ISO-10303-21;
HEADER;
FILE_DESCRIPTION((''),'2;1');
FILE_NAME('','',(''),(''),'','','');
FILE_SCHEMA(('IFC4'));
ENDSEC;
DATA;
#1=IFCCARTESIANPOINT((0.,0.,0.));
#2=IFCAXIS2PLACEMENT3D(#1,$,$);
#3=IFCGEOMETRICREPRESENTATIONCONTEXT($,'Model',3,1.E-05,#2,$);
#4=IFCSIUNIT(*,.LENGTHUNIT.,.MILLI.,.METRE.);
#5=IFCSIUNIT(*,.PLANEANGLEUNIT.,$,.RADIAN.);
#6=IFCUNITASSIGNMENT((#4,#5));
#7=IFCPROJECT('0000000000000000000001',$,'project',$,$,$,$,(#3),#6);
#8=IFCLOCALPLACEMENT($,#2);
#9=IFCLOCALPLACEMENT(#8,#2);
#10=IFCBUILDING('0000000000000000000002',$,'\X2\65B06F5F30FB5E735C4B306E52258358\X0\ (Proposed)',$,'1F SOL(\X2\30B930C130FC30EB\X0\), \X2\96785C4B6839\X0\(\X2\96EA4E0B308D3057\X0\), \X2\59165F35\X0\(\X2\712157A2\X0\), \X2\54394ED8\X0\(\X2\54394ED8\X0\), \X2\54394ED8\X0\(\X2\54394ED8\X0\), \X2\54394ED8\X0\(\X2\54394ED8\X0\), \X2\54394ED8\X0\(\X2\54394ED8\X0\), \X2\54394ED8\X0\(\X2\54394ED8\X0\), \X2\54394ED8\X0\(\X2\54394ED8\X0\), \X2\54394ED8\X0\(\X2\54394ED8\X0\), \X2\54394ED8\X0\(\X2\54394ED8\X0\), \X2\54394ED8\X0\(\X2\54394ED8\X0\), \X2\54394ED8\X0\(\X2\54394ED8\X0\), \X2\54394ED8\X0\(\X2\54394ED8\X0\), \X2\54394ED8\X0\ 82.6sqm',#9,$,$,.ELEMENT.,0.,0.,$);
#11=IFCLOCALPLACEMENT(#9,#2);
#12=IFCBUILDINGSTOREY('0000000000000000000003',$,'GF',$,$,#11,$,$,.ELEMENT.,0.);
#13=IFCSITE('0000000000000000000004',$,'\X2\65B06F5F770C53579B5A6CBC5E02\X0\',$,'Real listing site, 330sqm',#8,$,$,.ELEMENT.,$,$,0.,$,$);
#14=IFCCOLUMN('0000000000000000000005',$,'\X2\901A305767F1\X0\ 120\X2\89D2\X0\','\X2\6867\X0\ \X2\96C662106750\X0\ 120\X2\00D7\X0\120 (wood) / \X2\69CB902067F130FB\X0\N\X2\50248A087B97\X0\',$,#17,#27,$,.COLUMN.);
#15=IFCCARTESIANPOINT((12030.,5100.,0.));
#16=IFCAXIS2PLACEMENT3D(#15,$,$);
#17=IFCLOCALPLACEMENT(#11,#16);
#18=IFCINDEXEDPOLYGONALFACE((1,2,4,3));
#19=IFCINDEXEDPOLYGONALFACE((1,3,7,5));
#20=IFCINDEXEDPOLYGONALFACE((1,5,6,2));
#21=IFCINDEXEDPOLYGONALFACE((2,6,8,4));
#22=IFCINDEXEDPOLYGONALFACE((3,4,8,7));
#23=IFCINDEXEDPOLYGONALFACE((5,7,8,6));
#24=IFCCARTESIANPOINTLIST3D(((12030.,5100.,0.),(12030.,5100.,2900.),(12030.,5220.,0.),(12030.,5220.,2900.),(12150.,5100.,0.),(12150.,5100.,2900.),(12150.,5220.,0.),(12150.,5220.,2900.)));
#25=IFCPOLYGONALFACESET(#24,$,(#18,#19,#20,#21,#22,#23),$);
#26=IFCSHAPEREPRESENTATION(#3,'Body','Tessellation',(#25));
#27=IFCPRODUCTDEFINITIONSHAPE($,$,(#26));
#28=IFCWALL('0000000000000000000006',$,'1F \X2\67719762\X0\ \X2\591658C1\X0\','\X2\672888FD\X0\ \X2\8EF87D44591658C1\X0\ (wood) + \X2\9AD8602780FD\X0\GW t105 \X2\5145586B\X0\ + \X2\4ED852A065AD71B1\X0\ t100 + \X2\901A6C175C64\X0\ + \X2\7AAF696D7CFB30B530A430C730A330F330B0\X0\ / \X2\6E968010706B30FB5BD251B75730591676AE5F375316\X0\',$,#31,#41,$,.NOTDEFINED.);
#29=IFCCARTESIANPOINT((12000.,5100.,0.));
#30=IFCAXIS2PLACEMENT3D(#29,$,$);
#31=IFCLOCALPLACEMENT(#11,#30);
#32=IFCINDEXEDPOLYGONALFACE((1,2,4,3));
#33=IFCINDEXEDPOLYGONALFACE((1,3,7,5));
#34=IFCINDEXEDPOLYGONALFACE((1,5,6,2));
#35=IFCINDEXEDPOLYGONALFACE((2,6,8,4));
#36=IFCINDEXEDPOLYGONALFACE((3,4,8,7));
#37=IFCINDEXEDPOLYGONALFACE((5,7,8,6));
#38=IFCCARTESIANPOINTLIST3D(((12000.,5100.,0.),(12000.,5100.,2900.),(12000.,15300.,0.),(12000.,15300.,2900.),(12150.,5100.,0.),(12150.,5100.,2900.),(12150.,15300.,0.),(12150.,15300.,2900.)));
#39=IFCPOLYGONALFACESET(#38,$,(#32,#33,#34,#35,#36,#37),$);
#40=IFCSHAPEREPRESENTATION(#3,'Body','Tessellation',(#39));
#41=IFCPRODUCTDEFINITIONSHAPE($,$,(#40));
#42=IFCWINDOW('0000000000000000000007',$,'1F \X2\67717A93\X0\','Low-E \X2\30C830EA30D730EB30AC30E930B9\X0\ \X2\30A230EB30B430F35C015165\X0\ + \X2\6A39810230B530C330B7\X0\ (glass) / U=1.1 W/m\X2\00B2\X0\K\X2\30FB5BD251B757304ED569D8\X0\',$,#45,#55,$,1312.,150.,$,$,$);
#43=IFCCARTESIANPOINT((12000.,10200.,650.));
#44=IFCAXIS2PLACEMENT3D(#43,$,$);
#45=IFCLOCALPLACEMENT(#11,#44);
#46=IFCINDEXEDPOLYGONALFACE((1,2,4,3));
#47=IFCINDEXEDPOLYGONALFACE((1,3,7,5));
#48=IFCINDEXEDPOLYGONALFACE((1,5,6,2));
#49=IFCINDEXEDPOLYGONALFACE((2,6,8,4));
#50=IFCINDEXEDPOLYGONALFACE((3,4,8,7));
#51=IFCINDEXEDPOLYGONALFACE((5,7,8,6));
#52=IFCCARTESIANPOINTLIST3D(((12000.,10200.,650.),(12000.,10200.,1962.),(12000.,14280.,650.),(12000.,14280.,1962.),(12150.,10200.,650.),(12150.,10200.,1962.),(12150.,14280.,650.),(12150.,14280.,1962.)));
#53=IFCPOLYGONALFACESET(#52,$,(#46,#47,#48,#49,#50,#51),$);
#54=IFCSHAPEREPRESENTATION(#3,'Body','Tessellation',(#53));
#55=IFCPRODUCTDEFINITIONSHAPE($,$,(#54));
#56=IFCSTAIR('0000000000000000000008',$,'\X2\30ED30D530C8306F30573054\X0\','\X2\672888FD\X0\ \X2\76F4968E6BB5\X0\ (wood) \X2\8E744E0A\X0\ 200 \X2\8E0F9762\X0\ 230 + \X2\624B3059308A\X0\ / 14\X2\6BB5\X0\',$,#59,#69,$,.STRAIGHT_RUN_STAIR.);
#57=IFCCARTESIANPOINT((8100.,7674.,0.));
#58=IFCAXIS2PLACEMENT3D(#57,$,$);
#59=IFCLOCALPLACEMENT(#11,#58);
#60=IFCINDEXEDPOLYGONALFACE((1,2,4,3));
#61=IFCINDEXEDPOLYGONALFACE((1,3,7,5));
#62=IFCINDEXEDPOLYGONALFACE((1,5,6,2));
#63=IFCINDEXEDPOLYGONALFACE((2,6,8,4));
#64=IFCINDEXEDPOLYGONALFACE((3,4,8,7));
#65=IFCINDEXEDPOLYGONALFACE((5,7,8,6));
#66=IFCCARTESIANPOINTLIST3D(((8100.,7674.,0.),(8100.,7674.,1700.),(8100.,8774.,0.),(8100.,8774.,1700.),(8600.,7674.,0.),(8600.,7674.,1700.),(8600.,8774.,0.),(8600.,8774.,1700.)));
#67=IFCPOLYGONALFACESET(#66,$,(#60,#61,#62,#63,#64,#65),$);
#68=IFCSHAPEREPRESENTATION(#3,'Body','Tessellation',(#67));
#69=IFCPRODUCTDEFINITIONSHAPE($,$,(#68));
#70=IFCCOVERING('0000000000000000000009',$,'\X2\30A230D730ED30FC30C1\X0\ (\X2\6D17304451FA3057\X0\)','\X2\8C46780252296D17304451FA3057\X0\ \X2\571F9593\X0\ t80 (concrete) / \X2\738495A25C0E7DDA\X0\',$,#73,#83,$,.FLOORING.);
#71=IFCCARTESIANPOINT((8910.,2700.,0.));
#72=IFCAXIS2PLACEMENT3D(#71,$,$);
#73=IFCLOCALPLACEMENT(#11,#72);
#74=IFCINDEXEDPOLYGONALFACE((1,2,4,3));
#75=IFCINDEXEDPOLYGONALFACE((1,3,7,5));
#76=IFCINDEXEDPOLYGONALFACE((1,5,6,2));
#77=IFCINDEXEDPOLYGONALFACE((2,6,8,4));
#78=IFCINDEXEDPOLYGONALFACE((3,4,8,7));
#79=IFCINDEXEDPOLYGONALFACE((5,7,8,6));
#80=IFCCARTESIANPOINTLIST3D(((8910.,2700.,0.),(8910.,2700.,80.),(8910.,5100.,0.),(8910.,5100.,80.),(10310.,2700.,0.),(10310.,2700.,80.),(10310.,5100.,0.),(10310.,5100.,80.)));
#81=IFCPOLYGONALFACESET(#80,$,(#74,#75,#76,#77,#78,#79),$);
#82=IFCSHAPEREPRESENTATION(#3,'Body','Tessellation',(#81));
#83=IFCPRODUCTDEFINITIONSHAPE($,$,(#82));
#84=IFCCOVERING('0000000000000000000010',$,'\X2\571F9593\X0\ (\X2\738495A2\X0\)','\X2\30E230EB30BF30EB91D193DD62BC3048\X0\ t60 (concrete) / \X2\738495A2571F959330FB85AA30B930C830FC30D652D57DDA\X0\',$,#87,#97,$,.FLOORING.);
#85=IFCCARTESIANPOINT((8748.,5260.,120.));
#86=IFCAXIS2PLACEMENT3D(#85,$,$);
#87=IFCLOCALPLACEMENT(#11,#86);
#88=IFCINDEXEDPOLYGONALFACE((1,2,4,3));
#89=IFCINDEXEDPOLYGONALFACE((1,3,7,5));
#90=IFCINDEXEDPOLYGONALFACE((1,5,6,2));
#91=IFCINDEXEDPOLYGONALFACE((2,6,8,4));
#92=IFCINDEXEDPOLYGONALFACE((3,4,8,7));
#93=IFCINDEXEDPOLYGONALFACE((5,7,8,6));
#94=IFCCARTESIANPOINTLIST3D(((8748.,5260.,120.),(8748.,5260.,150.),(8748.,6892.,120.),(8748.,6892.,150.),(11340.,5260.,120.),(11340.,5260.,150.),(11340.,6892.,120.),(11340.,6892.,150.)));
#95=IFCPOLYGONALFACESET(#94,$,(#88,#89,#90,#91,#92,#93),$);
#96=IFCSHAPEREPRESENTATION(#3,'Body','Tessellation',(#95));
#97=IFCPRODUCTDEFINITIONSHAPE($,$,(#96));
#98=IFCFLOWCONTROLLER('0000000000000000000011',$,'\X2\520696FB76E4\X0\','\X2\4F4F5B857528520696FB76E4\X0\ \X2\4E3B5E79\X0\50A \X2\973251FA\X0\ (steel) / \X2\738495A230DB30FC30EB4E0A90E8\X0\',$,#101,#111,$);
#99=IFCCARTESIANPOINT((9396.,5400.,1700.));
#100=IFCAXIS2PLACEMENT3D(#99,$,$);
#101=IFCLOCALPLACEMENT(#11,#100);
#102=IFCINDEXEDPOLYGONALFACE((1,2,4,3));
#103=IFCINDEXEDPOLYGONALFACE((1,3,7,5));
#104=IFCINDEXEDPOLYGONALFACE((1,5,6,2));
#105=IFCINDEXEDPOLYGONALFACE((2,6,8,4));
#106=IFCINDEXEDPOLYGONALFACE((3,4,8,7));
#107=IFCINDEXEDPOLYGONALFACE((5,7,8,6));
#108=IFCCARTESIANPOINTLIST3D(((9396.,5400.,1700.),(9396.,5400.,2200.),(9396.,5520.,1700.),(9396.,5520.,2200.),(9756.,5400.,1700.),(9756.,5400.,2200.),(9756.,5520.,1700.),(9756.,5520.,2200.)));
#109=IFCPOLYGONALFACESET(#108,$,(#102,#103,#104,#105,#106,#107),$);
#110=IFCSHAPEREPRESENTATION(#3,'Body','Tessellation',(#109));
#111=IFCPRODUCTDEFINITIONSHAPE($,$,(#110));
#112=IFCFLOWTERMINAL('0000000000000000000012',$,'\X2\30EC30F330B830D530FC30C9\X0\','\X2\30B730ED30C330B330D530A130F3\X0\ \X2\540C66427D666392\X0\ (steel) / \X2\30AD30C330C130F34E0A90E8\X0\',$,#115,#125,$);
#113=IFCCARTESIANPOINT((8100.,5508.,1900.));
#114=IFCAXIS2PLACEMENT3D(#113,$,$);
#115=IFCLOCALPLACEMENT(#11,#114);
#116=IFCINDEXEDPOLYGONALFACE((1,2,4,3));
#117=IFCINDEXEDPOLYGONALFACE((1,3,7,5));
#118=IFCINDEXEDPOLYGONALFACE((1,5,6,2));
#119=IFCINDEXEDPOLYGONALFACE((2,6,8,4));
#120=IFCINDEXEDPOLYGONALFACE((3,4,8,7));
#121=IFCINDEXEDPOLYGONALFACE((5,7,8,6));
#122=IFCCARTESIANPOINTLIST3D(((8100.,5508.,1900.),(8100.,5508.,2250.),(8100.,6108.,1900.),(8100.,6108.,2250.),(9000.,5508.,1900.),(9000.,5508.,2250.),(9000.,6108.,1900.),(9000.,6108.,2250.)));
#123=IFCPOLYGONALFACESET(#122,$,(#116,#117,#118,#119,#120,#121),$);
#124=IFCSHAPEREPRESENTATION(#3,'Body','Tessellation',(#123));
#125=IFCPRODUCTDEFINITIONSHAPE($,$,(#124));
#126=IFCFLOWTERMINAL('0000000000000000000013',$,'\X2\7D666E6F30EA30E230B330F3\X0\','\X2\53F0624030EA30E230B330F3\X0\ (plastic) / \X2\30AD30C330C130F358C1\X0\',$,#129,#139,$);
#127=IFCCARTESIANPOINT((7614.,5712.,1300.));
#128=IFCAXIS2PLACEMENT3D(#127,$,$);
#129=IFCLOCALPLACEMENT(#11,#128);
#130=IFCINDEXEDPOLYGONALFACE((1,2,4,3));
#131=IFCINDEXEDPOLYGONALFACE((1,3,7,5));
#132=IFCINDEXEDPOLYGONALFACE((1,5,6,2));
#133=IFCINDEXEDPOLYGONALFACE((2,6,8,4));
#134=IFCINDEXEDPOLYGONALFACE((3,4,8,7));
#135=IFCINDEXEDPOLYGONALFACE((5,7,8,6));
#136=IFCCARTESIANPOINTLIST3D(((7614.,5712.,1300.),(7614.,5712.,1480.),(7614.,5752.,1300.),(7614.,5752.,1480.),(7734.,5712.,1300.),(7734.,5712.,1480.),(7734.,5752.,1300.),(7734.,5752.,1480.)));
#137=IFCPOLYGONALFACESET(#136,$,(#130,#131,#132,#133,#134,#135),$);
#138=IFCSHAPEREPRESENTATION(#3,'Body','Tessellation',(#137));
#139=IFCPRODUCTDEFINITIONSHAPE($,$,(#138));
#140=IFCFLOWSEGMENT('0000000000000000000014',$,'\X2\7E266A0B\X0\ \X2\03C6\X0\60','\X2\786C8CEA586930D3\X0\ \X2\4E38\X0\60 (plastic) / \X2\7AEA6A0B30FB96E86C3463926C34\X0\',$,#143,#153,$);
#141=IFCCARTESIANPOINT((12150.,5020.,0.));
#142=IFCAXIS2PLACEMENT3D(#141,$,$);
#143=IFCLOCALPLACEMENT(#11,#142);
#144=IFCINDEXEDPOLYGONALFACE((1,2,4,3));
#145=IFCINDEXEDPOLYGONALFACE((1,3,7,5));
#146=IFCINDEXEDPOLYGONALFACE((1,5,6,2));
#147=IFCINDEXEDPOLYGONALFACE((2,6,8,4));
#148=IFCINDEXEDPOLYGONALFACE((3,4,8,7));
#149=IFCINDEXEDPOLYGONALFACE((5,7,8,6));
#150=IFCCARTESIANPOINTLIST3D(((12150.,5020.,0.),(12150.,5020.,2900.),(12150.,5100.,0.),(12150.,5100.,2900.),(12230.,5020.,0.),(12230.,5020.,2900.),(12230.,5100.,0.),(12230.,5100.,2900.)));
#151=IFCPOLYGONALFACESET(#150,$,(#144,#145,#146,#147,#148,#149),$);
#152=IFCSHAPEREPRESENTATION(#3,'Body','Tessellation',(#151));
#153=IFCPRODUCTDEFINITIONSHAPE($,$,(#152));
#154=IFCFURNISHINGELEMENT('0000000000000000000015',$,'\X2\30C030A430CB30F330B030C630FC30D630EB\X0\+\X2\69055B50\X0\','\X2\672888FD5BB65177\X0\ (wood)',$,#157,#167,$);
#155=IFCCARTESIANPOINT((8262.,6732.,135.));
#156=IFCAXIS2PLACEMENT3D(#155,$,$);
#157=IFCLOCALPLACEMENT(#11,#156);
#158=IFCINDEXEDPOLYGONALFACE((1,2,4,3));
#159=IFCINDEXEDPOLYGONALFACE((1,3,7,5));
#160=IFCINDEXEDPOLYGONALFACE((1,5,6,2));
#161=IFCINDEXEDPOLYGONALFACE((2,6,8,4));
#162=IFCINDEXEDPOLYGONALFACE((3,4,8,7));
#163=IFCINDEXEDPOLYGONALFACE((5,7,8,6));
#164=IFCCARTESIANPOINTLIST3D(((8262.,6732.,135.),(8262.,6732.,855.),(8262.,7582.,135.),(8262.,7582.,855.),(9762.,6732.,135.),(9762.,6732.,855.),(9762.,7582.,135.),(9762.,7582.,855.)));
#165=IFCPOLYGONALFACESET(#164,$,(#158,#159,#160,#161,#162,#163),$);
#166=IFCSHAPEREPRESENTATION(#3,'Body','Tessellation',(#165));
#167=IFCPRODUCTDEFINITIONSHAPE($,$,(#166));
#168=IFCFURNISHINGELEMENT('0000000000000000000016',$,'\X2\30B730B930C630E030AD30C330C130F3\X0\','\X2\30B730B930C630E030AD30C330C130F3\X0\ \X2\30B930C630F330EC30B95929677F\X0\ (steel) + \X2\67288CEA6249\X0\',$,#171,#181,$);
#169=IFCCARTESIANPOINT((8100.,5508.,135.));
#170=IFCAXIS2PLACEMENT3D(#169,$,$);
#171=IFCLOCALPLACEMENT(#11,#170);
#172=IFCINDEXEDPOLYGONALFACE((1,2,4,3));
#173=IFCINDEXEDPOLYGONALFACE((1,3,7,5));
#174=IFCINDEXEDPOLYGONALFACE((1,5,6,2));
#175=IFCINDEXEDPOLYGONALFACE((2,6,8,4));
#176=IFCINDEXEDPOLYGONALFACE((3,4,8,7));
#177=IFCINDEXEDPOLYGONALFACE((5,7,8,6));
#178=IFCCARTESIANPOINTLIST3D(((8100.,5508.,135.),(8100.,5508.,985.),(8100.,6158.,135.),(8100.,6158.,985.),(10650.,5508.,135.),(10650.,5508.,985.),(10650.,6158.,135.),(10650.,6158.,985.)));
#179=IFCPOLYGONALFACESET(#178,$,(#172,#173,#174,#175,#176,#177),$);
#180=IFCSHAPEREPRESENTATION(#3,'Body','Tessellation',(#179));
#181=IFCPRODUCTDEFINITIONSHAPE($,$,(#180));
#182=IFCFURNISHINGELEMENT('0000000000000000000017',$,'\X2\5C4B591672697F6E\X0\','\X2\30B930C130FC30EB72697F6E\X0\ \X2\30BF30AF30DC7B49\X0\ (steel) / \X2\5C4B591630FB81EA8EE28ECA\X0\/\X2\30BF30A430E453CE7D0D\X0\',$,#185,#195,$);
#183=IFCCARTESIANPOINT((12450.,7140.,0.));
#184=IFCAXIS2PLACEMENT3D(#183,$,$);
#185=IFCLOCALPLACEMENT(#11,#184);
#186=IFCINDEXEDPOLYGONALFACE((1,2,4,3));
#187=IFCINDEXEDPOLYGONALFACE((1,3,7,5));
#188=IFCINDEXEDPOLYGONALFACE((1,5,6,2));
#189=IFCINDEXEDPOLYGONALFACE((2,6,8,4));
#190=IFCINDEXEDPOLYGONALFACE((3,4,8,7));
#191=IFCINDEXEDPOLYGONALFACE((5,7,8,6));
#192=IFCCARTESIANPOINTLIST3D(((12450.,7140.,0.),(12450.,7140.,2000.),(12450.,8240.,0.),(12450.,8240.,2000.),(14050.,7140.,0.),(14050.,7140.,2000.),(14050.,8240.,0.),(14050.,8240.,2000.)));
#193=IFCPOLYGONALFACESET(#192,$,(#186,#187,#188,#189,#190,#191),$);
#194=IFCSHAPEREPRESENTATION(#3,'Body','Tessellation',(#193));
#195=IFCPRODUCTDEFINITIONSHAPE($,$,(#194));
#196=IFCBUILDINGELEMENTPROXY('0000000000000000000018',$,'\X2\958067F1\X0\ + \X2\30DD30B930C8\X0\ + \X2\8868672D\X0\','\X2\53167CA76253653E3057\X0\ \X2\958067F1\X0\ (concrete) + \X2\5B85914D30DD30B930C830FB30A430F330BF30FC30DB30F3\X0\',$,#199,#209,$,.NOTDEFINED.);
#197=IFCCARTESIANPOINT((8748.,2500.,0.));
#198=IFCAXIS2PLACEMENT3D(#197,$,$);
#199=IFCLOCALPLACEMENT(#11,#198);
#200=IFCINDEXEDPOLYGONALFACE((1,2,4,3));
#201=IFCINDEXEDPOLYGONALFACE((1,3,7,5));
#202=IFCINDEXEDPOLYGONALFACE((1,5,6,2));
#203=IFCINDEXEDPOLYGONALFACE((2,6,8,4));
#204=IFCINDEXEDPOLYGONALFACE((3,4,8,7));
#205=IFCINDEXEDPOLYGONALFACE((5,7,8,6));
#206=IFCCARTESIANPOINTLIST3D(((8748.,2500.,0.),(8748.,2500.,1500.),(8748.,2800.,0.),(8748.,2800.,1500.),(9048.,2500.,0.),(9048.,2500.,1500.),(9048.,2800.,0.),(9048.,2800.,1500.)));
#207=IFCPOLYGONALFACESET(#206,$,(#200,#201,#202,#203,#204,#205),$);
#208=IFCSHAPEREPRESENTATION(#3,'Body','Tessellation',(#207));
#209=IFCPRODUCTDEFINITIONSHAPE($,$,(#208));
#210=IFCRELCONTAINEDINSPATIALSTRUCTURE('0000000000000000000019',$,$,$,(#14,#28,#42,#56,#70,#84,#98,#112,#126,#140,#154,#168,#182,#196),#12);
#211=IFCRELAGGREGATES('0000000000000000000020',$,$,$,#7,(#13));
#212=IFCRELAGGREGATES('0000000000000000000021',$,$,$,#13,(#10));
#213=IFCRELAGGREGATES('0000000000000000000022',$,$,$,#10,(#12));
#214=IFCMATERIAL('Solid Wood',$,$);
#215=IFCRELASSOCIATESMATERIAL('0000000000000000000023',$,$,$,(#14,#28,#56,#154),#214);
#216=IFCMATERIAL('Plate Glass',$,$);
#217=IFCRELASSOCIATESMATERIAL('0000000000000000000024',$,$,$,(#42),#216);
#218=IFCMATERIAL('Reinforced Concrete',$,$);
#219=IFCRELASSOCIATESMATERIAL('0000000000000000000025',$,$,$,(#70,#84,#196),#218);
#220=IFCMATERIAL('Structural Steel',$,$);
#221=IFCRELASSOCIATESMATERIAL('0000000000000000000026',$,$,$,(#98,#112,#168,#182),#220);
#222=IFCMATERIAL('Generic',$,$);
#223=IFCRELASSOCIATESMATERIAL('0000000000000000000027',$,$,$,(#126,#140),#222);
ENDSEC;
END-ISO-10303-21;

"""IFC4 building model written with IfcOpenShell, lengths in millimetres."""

from ifc_helpers import new_model, si_unit, frame, frame_2d, origin, place, context, project, spatial, rectangle, extrude, material, element, fill, save


model = new_model("IFC4")

# Units and contexts
model_context = context("Model", 3, precision=1e-05, world=origin())
ifc_project = project(units=[si_unit("LENGTHUNIT", "METRE", prefix="MILLI"), si_unit("PLANEANGLEUNIT", "RADIAN")], contexts=[model_context])

# Site, building, storey
site_placement = place(None, origin())
site = spatial("IfcSite", under=ifc_project, at=site_placement, Name="新潟県南魚沼市", ObjectType="Real listing site, 330sqm", CompositionType="ELEMENT", RefElevation=0.0)
building_placement = place(site_placement, origin())
building = spatial("IfcBuilding", under=site, at=building_placement, Name="新潟・平屋の別荘 (Proposed)", ObjectType="1F SOL(スチール), 陸屋根(雪下ろし), 外張(無垢), 吹付(吹付), 吹付(吹付), 吹付(吹付), 吹付(吹付), 吹付(吹付), 吹付(吹付), 吹付(吹付), 吹付(吹付), 吹付(吹付), 吹付(吹付), 吹付(吹付), 吹付 82.6sqm", CompositionType="ELEMENT", ElevationOfRefHeight=0.0, ElevationOfTerrain=0.0)
storey_placement = place(building_placement, origin())
storey = spatial("IfcBuildingStorey", under=building, at=storey_placement, Name="GF", CompositionType="ELEMENT", Elevation=0.0)

# Column
ifc_material_1 = material(Name="Solid Wood")
column_1_placement = place(storey_placement, frame((12030.0, 5100.0, 0.0)))
element("IfcColumn", 1, at=column_1_placement, inside=storey, material=ifc_material_1, Name="通し柱 120角", Description="桧 集成材 120×120 (wood) / 構造柱・N値計算", PredefinedType="COLUMN", context=model_context, shape_type="SweptSolid", body=[
    extrude(rectangle(XDim=120.0, YDim=120.0, at=frame_2d((60.0, 60.0))), frame((12030.0, 5100.0, 0.0)), (0.0, 0.0, 1.0), 2900.0),
])

# Wall, opening, window
wall_1_placement = place(storey_placement, frame((12000.0, 5100.0, 0.0)))
wall_1 = element("IfcWall", 2, at=wall_1_placement, inside=storey, material=ifc_material_1, Name="1F 東面 外壁", Description="木製 軸組外壁 (wood) + 高性能GW t105 充填 + 付加断熱 t100 + 通気層 + 窯業系サイディング / 準耐火・寒冷地外皮強化", PredefinedType="NOTDEFINED", context=model_context, shape_type="SweptSolid", body=[
    extrude(rectangle(XDim=150.0, YDim=10200.0, at=frame_2d((75.0, 5100.0))), frame((12000.0, 5100.0, 0.0)), (0.0, 0.0, 1.0), 2900.0),
])
opening_placement = place(storey_placement, frame((12000.0, 10200.0, 650.0)))
opening = element("IfcOpeningElement", 3, at=opening_placement, cuts=wall_1, PredefinedType="NOTDEFINED", context=model_context, shape_type="SweptSolid", body=[
    extrude(rectangle(XDim=150.0, YDim=4080.0, at=frame_2d((75.0, 2040.0))), frame((12000.0, 10200.0, 650.0)), (0.0, 0.0, 1.0), 1312.0),
])
ifc_material_2 = material(Name="Plate Glass")
window_placement = place(storey_placement, frame((12000.0, 10200.0, 650.0)))
window = element("IfcWindow", 4, at=window_placement, inside=storey, material=ifc_material_2, Name="1F 東窓", Description="Low-E トリプルガラス アルゴン封入 + 樹脂サッシ (glass) / U=1.1 W/m²K・寒冷地仕様", OverallHeight=1312.0, OverallWidth=150.0, context=model_context, shape_type="SweptSolid", body=[
    extrude(rectangle(XDim=150.0, YDim=4080.0, at=frame_2d((75.0, 2040.0))), frame((12000.0, 10200.0, 650.0)), (0.0, 0.0, 1.0), 1312.0),
])
fill(opening, window)

# Stair
stair_placement = place(storey_placement, frame((8100.0, 7674.0, 0.0)))
element("IfcStair", 5, at=stair_placement, inside=storey, material=ifc_material_1, Name="ロフトはしご", Description="木製 直階段 (wood) 蹴上 200 踏面 230 + 手すり / 14段", PredefinedType="STRAIGHT_RUN_STAIR", context=model_context, shape_type="SweptSolid", body=[
    extrude(rectangle(XDim=500.0, YDim=1100.0, at=frame_2d((250.0, 550.0))), frame((8100.0, 7674.0, 0.0)), (0.0, 0.0, 1.0), 1700.0),
])

# Coverings
ifc_material_3 = material(Name="Reinforced Concrete")
covering_1_placement = place(storey_placement, frame((8910.0, 2700.0, 0.0)))
element("IfcCovering", 6, at=covering_1_placement, inside=storey, material=ifc_material_3, Name="アプローチ (洗い出し)", Description="豆砂利洗い出し 土間 t80 (concrete) / 玄関導線", PredefinedType="FLOORING", context=model_context, shape_type="SweptSolid", body=[
    extrude(rectangle(XDim=1400.0, YDim=2400.0, at=frame_2d((700.0, 1200.0))), frame((8910.0, 2700.0, 0.0)), (0.0, 0.0, 1.0), 80.0),
])
covering_2_placement = place(storey_placement, frame((8748.0, 5260.0, 120.0)))
element("IfcCovering", 7, at=covering_2_placement, inside=storey, material=ifc_material_3, Name="土間 (玄関)", Description="モルタル金鏝押え t60 (concrete) / 玄関土間・薪ストーブ動線", PredefinedType="FLOORING", context=model_context, shape_type="SweptSolid", body=[
    extrude(rectangle(XDim=2592.0, YDim=1632.0, at=frame_2d((1296.0, 816.0))), frame((8748.0, 5260.0, 120.0)), (0.0, 0.0, 1.0), 30.0),
])

# Flow controller
ifc_material_4 = material(Name="Structural Steel")
flow_controller_placement = place(storey_placement, frame((9396.0, 5400.0, 1700.0)))
element("IfcFlowController", 8, at=flow_controller_placement, inside=storey, material=ifc_material_4, Name="分電盤", Description="住宅用分電盤 主幹50A 露出 (steel) / 玄関ホール上部", context=model_context, shape_type="SweptSolid", body=[
    extrude(rectangle(XDim=360.0, YDim=120.0, at=frame_2d((180.0, 60.0))), frame((9396.0, 5400.0, 1700.0)), (0.0, 0.0, 1.0), 500.0),
])

# Flow terminals
flow_terminal_1_placement = place(storey_placement, frame((8100.0, 5508.0, 1900.0)))
element("IfcFlowTerminal", 9, at=flow_terminal_1_placement, inside=storey, material=ifc_material_4, Name="レンジフード", Description="シロッコファン 同時給排 (steel) / キッチン上部", context=model_context, shape_type="SweptSolid", body=[
    extrude(rectangle(XDim=900.0, YDim=600.0, at=frame_2d((450.0, 300.0))), frame((8100.0, 5508.0, 1900.0)), (0.0, 0.0, 1.0), 350.0),
])
ifc_material_5 = material(Name="Generic")
flow_terminal_2_placement = place(storey_placement, frame((7614.0, 5712.0, 1300.0)))
element("IfcFlowTerminal", 10, at=flow_terminal_2_placement, inside=storey, material=ifc_material_5, Name="給湯リモコン", Description="台所リモコン (plastic) / キッチン壁", context=model_context, shape_type="SweptSolid", body=[
    extrude(rectangle(XDim=120.0, YDim=40.0, at=frame_2d((60.0, 20.0))), frame((7614.0, 5712.0, 1300.0)), (0.0, 0.0, 1.0), 180.0),
])

# Flow segment
flow_segment_placement = place(storey_placement, frame((12150.0, 5020.0, 0.0)))
element("IfcFlowSegment", 11, at=flow_segment_placement, inside=storey, material=ifc_material_5, Name="縦樋 φ60", Description="硬質塩ビ 丸60 (plastic) / 竪樋・雨水排水", context=model_context, shape_type="SweptSolid", body=[
    extrude(rectangle(XDim=80.0, YDim=80.0, at=frame_2d((40.0, 40.0))), frame((12150.0, 5020.0, 0.0)), (0.0, 0.0, 1.0), 2900.0),
])

# Furnishing elements
furnishing_1_placement = place(storey_placement, frame((8262.0, 6732.0, 135.0)))
element("IfcFurnishingElement", 12, at=furnishing_1_placement, inside=storey, material=ifc_material_1, Name="ダイニングテーブル+椅子", Description="木製家具 (wood)", context=model_context, shape_type="SweptSolid", body=[
    extrude(rectangle(XDim=1500.0, YDim=850.0, at=frame_2d((750.0, 425.0))), frame((8262.0, 6732.0, 135.0)), (0.0, 0.0, 1.0), 720.0),
])
furnishing_2_placement = place(storey_placement, frame((8100.0, 5508.0, 135.0)))
element("IfcFurnishingElement", 13, at=furnishing_2_placement, inside=storey, material=ifc_material_4, Name="システムキッチン", Description="システムキッチン ステンレス天板 (steel) + 木質扉", context=model_context, shape_type="SweptSolid", body=[
    extrude(rectangle(XDim=2550.0, YDim=650.0, at=frame_2d((1275.0, 325.0))), frame((8100.0, 5508.0, 135.0)), (0.0, 0.0, 1.0), 850.0),
])
furnishing_3_placement = place(storey_placement, frame((12450.0, 7140.0, 0.0)))
element("IfcFurnishingElement", 14, at=furnishing_3_placement, inside=storey, material=ifc_material_4, Name="屋外物置", Description="スチール物置 タクボ等 (steel) / 屋外・自転車/タイヤ収納", context=model_context, shape_type="SweptSolid", body=[
    extrude(rectangle(XDim=1600.0, YDim=1100.0, at=frame_2d((800.0, 550.0))), frame((12450.0, 7140.0, 0.0)), (0.0, 0.0, 1.0), 2000.0),
])

# Building element proxy
proxy_placement = place(storey_placement, frame((8748.0, 2500.0, 0.0)))
element("IfcBuildingElementProxy", 15, at=proxy_placement, inside=storey, material=ifc_material_3, Name="門柱 + ポスト + 表札", Description="化粧打放し 門柱 (concrete) + 宅配ポスト・インターホン", PredefinedType="NOTDEFINED", context=model_context, shape_type="SweptSolid", body=[
    extrude(rectangle(XDim=300.0, YDim=300.0, at=frame_2d((150.0, 150.0))), frame((8748.0, 2500.0, 0.0)), (0.0, 0.0, 1.0), 1500.0),
])

save(model, "model.ifc")
